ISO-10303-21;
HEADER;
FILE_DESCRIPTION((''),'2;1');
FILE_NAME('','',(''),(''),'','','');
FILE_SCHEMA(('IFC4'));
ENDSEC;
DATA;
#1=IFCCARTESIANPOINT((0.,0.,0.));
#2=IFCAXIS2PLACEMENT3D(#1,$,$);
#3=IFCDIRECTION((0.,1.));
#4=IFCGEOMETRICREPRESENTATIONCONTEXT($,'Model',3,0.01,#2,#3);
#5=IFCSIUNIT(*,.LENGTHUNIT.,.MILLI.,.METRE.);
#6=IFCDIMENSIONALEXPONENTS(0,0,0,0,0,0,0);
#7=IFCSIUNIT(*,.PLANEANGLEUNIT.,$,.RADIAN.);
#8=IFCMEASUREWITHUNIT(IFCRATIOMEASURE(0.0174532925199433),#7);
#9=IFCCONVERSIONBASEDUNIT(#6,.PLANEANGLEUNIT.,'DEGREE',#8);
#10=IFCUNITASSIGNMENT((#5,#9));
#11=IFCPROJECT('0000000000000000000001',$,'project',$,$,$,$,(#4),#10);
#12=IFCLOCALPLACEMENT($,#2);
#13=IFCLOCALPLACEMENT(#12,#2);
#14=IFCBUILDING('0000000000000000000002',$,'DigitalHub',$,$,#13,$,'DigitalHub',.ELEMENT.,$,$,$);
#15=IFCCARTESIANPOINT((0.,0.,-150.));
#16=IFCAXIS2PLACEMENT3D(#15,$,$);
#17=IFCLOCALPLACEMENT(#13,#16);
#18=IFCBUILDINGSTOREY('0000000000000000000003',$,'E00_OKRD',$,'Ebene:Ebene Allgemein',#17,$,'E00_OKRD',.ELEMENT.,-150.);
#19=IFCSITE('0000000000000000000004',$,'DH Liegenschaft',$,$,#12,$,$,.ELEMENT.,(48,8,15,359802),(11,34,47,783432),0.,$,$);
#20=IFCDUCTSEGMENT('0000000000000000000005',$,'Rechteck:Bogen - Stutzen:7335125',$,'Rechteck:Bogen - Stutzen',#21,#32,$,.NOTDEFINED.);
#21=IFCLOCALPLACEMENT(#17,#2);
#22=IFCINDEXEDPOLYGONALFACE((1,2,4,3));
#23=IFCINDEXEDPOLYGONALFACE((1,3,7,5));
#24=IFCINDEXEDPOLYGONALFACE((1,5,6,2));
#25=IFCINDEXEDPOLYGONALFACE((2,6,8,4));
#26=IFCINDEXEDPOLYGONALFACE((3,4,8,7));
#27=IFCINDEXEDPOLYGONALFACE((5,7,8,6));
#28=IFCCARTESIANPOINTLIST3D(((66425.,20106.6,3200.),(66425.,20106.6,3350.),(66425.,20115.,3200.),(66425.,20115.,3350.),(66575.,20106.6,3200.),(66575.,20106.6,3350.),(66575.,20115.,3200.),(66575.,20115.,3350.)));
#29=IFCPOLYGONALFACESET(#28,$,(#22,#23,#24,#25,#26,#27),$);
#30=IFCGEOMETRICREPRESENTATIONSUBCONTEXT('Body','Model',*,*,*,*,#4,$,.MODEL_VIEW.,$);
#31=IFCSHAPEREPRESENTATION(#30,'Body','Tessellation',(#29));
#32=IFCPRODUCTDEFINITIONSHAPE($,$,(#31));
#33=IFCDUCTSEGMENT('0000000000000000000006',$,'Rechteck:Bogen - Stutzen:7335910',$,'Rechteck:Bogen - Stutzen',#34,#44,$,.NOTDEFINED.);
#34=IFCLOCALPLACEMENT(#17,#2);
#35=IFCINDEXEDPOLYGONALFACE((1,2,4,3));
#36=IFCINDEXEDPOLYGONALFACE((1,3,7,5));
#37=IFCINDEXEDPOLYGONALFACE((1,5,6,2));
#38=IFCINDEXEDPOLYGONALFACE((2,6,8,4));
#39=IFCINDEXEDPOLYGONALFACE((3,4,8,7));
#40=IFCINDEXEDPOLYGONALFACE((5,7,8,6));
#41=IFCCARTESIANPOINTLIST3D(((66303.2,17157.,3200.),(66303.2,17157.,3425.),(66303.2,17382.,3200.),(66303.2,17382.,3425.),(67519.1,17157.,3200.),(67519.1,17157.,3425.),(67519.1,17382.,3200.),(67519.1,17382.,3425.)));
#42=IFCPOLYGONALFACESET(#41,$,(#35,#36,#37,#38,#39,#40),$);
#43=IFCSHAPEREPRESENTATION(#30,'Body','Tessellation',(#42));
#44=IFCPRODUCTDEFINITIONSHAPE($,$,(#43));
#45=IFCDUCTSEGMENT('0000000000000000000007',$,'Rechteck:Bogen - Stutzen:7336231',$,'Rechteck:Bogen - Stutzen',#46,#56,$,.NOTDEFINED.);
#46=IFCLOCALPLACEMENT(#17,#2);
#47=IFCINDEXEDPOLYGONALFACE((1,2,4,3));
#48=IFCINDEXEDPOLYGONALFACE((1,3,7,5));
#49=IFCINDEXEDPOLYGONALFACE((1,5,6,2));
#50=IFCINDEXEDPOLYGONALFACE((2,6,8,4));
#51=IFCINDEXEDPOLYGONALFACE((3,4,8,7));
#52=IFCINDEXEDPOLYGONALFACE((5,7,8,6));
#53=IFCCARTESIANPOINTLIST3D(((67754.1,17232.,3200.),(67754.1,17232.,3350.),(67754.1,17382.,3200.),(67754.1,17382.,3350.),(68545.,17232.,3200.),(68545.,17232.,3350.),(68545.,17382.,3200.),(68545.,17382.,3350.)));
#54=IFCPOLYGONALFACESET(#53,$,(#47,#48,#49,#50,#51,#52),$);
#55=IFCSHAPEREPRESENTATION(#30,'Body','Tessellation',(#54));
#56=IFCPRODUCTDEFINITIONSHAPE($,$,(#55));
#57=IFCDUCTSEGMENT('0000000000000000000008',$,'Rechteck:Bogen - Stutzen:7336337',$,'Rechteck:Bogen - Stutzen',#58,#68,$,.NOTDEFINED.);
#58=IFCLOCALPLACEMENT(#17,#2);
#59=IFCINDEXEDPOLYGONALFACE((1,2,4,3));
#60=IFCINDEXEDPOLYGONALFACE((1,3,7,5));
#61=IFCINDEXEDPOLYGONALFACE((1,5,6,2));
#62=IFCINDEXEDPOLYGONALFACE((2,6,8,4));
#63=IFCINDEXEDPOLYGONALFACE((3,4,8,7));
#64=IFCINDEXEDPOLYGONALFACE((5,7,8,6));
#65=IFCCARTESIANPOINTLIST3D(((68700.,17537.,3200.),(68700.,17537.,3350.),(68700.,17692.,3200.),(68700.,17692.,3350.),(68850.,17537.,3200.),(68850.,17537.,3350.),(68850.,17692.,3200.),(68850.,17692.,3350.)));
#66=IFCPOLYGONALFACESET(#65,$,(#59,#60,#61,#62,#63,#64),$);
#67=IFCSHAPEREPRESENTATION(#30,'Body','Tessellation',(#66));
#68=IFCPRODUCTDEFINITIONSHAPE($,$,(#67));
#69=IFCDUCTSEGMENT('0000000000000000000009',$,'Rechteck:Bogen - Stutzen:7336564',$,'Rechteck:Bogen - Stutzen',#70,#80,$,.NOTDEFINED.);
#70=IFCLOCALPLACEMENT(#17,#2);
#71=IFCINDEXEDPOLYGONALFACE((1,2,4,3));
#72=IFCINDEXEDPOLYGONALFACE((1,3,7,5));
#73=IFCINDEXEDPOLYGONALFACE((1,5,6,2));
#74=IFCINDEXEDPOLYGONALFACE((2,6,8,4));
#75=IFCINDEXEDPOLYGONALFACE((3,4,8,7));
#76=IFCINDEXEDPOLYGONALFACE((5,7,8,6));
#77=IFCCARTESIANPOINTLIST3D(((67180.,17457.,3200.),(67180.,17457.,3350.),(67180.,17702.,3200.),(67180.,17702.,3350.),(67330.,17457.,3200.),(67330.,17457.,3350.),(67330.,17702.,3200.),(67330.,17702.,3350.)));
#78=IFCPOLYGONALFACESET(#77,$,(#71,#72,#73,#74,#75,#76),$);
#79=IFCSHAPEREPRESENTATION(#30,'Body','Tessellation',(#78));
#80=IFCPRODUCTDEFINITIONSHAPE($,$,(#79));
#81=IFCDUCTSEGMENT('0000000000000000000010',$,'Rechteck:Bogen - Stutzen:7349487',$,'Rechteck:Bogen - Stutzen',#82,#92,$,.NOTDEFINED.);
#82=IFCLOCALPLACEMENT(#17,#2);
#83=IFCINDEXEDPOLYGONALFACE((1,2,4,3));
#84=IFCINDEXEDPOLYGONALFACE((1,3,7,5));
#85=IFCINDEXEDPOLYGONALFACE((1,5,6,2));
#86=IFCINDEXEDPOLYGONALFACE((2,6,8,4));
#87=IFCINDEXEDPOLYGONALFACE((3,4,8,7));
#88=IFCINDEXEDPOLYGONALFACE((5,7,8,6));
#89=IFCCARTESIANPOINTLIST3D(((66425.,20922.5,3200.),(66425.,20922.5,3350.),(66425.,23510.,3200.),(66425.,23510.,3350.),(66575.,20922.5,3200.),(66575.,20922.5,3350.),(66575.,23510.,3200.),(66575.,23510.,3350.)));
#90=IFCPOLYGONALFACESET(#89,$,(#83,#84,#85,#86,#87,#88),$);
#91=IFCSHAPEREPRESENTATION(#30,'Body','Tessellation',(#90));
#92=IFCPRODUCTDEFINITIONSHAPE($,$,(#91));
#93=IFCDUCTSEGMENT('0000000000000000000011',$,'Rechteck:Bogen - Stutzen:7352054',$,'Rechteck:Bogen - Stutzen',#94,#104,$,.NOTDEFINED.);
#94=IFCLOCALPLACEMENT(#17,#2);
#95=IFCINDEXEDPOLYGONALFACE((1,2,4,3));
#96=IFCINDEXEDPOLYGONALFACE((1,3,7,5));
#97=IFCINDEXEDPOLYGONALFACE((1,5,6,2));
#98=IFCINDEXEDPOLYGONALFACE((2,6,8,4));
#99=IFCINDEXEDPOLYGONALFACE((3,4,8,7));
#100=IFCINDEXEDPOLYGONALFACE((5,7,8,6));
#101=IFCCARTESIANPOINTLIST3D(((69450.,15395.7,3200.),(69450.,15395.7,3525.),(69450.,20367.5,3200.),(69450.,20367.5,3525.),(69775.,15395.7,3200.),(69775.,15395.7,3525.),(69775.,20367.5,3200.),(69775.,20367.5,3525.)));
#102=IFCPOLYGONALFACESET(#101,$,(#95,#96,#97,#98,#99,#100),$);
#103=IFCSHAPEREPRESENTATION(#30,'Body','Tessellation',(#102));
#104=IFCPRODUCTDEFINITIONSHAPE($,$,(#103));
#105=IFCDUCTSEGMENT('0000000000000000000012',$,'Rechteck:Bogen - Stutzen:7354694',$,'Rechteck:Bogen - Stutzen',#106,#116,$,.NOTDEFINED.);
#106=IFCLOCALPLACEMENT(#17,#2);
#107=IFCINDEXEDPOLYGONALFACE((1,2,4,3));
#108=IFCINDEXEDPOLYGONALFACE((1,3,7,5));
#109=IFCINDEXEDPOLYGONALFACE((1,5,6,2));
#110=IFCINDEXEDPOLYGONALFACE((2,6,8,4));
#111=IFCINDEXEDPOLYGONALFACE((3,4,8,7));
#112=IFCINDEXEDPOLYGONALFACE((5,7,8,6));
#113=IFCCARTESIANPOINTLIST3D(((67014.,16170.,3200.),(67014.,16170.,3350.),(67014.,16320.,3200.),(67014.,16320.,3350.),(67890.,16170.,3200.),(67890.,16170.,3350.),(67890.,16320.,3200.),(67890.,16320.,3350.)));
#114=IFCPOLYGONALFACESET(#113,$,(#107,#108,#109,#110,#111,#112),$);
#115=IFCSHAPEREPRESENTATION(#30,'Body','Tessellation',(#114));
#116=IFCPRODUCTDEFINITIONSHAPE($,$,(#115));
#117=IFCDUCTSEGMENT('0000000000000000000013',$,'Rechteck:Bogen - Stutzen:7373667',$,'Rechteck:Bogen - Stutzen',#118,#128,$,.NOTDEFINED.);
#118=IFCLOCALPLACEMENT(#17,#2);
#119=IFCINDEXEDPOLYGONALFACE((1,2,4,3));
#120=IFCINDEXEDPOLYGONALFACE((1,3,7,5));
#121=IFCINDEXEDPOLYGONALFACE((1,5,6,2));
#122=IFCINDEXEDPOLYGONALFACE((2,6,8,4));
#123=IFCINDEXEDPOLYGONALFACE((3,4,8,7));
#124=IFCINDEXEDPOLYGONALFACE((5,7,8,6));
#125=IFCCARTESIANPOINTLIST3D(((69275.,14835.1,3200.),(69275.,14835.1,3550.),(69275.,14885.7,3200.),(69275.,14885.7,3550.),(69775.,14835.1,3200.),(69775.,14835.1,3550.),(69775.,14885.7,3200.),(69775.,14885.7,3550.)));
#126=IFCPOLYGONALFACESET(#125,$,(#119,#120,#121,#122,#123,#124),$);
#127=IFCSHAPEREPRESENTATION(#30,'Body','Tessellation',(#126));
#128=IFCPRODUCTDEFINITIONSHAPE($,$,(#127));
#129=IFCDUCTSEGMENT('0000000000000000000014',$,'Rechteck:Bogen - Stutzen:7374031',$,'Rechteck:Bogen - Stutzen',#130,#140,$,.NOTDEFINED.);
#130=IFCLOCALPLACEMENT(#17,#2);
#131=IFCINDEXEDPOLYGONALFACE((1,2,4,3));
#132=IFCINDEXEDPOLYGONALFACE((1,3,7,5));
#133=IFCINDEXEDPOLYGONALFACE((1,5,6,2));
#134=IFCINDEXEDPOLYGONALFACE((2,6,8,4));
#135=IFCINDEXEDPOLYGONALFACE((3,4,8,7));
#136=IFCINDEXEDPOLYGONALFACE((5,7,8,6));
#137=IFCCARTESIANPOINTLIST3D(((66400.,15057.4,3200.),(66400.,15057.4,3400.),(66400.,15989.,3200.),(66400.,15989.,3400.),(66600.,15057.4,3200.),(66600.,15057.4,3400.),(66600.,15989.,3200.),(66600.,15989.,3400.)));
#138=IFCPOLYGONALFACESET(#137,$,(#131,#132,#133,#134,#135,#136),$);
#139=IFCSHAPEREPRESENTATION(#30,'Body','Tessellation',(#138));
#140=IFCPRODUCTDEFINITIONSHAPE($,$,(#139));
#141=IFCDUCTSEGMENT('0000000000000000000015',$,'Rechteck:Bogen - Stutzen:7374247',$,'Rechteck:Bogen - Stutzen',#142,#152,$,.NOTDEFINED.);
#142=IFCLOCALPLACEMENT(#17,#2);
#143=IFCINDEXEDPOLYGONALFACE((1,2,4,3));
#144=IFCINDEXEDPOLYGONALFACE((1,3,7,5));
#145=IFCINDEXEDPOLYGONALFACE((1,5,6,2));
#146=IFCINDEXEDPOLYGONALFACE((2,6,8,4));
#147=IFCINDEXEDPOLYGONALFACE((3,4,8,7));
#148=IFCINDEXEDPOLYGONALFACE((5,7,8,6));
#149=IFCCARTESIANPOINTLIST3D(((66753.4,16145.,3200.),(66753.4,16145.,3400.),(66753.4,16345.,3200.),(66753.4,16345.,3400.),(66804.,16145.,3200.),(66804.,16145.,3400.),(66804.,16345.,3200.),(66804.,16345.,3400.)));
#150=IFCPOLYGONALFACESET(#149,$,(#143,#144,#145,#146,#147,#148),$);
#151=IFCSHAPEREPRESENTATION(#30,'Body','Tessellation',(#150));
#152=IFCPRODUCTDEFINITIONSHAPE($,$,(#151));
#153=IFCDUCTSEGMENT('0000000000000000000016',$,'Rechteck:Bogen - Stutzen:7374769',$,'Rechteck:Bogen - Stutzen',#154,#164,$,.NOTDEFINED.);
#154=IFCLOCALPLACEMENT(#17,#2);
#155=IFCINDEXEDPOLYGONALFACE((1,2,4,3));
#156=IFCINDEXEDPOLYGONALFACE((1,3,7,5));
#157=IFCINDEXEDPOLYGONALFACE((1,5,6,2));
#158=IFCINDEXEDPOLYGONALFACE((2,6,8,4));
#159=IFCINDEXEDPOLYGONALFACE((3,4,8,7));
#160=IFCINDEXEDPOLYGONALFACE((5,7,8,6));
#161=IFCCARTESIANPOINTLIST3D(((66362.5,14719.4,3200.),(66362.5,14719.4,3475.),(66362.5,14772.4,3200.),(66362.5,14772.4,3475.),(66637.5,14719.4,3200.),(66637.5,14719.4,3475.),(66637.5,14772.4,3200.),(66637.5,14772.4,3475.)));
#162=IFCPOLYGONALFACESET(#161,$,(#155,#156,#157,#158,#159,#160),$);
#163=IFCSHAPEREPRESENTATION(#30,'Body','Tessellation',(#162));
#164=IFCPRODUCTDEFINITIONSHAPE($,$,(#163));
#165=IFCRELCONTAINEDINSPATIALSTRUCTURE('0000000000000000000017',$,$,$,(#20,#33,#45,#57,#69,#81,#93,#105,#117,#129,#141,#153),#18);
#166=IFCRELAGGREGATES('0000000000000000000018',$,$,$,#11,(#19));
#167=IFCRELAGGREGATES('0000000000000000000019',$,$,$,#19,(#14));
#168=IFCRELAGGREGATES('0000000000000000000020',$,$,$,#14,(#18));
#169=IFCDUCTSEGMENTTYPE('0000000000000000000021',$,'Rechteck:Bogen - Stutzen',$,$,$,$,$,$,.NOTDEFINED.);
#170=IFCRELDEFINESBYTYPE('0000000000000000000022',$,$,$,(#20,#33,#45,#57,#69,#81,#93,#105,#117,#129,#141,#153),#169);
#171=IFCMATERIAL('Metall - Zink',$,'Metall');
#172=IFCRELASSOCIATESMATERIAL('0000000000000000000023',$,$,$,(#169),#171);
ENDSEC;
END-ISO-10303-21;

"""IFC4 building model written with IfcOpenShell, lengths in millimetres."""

from ifc_helpers import new_model, entity, si_unit, converted_unit, direction, frame, origin, place, context, subcontext, project, spatial, indexed_curve, outline, extrude, material, type_object, element, save


model = new_model("IFC4")

# Units and contexts
model_context = context("Model", 3, precision=0.01, world=origin(), true_north=direction((0.0, 1.0)))
body_context = subcontext(model_context, "Body", "Model", "MODEL_VIEW")
ifc_project = project(units=[si_unit("LENGTHUNIT", "METRE", prefix="MILLI"), converted_unit("PLANEANGLEUNIT", "DEGREE", entity("IfcRatioMeasure", 0.0174532925199433), si_unit("PLANEANGLEUNIT", "RADIAN"), dimensions=[0, 0, 0, 0, 0, 0, 0])], contexts=[model_context])

# Site, building, storey
site_placement = place(None, origin())
site = spatial("IfcSite", under=ifc_project, at=site_placement, Name="DH Liegenschaft", CompositionType="ELEMENT", RefLatitude=(48, 8, 15, 359802), RefLongitude=(11, 34, 47, 783432), RefElevation=0.0)
building_placement = place(site_placement, origin())
building = spatial("IfcBuilding", under=site, at=building_placement, Name="DigitalHub", LongName="DigitalHub", CompositionType="ELEMENT")
storey_placement = place(building_placement, frame((0.0, 0.0, -150.0)))
storey = spatial("IfcBuildingStorey", under=building, at=storey_placement, Name="E00_OKRD", ObjectType="Ebene:Ebene Allgemein", LongName="E00_OKRD", CompositionType="ELEMENT", Elevation=-150.0)

# Duct segments
ifc_material_1 = material(Name="Metall - Zink", Category="Metall")
duct_segment_type_1 = type_object("IfcDuctSegmentType", Name="Rechteck:Bogen - Stutzen", PredefinedType="NOTDEFINED", material=ifc_material_1)
duct_segment_1_placement = place(storey_placement, frame((66425.0, 20106.6, 3200.0)))
element("IfcDuctSegment", 1, at=duct_segment_1_placement, inside=storey, type_object=duct_segment_type_1, Name="Rechteck:Bogen - Stutzen:7335125", ObjectType="Rechteck:Bogen - Stutzen", PredefinedType="NOTDEFINED", context=body_context, shape_type="SweptSolid", body=[
    extrude(outline(indexed_curve([(-4.2, -75.0), (4.2, -75.0), (4.2, 75.0), (-4.2, 75.0), (-4.2, -75.0)], self_intersect=False)), frame((75.0, 4.2, 0.0), z_axis=(0.0, 0.0, 1.0), x_axis=(0.0, -1.0, 0.0)), (0.0, 0.0, 1.0), 150.0),
])
duct_segment_2_placement = place(storey_placement, frame((66303.2, 17157.0, 3200.0)))
element("IfcDuctSegment", 2, at=duct_segment_2_placement, inside=storey, type_object=duct_segment_type_1, Name="Rechteck:Bogen - Stutzen:7335910", ObjectType="Rechteck:Bogen - Stutzen", PredefinedType="NOTDEFINED", context=body_context, shape_type="SweptSolid", body=[
    extrude(outline(indexed_curve([(-607.9, -112.5), (607.9, -112.5), (607.9, 112.5), (-607.9, 112.5), (-607.9, -112.5)], self_intersect=False)), frame((607.9, 112.5, 0.0)), (0.0, 0.0, 1.0), 225.0),
])
duct_segment_3_placement = place(storey_placement, frame((67754.1, 17232.0, 3200.0)))
element("IfcDuctSegment", 3, at=duct_segment_3_placement, inside=storey, type_object=duct_segment_type_1, Name="Rechteck:Bogen - Stutzen:7336231", ObjectType="Rechteck:Bogen - Stutzen", PredefinedType="NOTDEFINED", context=body_context, shape_type="SweptSolid", body=[
    extrude(outline(indexed_curve([(-395.4, -75.0), (395.4, -75.0), (395.4, 75.0), (-395.4, 75.0), (-395.4, -75.0)], self_intersect=False)), frame((395.4, 75.0, 0.0), z_axis=(0.0, 0.0, 1.0), x_axis=(-1.0, 0.0, 0.0)), (0.0, 0.0, 1.0), 150.0),
])
duct_segment_4_placement = place(storey_placement, frame((68700.0, 17537.0, 3200.0)))
element("IfcDuctSegment", 4, at=duct_segment_4_placement, inside=storey, type_object=duct_segment_type_1, Name="Rechteck:Bogen - Stutzen:7336337", ObjectType="Rechteck:Bogen - Stutzen", PredefinedType="NOTDEFINED", context=body_context, shape_type="SweptSolid", body=[
    extrude(outline(indexed_curve([(-77.5, -75.0), (77.5, -75.0), (77.5, 75.0), (-77.5, 75.0), (-77.5, -75.0)], self_intersect=False)), frame((75.0, 77.5, 0.0), z_axis=(0.0, 0.0, 1.0), x_axis=(0.0, 1.0, 0.0)), (0.0, 0.0, 1.0), 150.0),
])
duct_segment_5_placement = place(storey_placement, frame((67180.0, 17457.0, 3200.0)))
element("IfcDuctSegment", 5, at=duct_segment_5_placement, inside=storey, type_object=duct_segment_type_1, Name="Rechteck:Bogen - Stutzen:7336564", ObjectType="Rechteck:Bogen - Stutzen", PredefinedType="NOTDEFINED", context=body_context, shape_type="SweptSolid", body=[
    extrude(outline(indexed_curve([(-122.5, -75.0), (122.5, -75.0), (122.5, 75.0), (-122.5, 75.0), (-122.5, -75.0)], self_intersect=False)), frame((75.0, 122.5, 0.0), z_axis=(0.0, 0.0, 1.0), x_axis=(0.0, 1.0, 0.0)), (0.0, 0.0, 1.0), 150.0),
])
duct_segment_6_placement = place(storey_placement, frame((66425.0, 20922.5, 3200.0)))
element("IfcDuctSegment", 6, at=duct_segment_6_placement, inside=storey, type_object=duct_segment_type_1, Name="Rechteck:Bogen - Stutzen:7349487", ObjectType="Rechteck:Bogen - Stutzen", PredefinedType="NOTDEFINED", context=body_context, shape_type="SweptSolid", body=[
    extrude(outline(indexed_curve([(-1293.7, -75.0), (1293.7, -75.0), (1293.7, 75.0), (-1293.7, 75.0), (-1293.7, -75.0)], self_intersect=False)), frame((75.0, 1293.7, 0.0), z_axis=(0.0, 0.0, 1.0), x_axis=(0.0, 1.0, 0.0)), (0.0, 0.0, 1.0), 150.0),
])
duct_segment_7_placement = place(storey_placement, frame((69450.0, 15395.7, 3200.0)))
element("IfcDuctSegment", 7, at=duct_segment_7_placement, inside=storey, type_object=duct_segment_type_1, Name="Rechteck:Bogen - Stutzen:7352054", ObjectType="Rechteck:Bogen - Stutzen", PredefinedType="NOTDEFINED", context=body_context, shape_type="SweptSolid", body=[
    extrude(outline(indexed_curve([(-2485.9, -162.5), (2485.9, -162.5), (2485.9, 162.5), (-2485.9, 162.5), (-2485.9, -162.5)], self_intersect=False)), frame((162.5, 2485.9, 0.0), z_axis=(0.0, 0.0, 1.0), x_axis=(0.0, -1.0, 0.0)), (0.0, 0.0, 1.0), 325.0),
])
duct_segment_8_placement = place(storey_placement, frame((67014.0, 16170.0, 3200.0)))
element("IfcDuctSegment", 8, at=duct_segment_8_placement, inside=storey, type_object=duct_segment_type_1, Name="Rechteck:Bogen - Stutzen:7354694", ObjectType="Rechteck:Bogen - Stutzen", PredefinedType="NOTDEFINED", context=body_context, shape_type="SweptSolid", body=[
    extrude(outline(indexed_curve([(-438.0, -75.0), (438.0, -75.0), (438.0, 75.0), (-438.0, 75.0), (-438.0, -75.0)], self_intersect=False)), frame((438.0, 75.0, 0.0), z_axis=(0.0, 0.0, 1.0), x_axis=(-1.0, 0.0, 0.0)), (0.0, 0.0, 1.0), 150.0),
])
duct_segment_9_placement = place(storey_placement, frame((69275.0, 14835.1, 3200.0)))
element("IfcDuctSegment", 9, at=duct_segment_9_placement, inside=storey, type_object=duct_segment_type_1, Name="Rechteck:Bogen - Stutzen:7373667", ObjectType="Rechteck:Bogen - Stutzen", PredefinedType="NOTDEFINED", context=body_context, shape_type="SweptSolid", body=[
    extrude(outline(indexed_curve([(-25.3, -250.0), (25.3, -250.0), (25.3, 250.0), (-25.3, 250.0), (-25.3, -250.0)], self_intersect=False)), frame((250.0, 25.3, 0.0), z_axis=(0.0, 0.0, 1.0), x_axis=(0.0, 1.0, 0.0)), (0.0, 0.0, 1.0), 350.0),
])
duct_segment_10_placement = place(storey_placement, frame((66400.0, 15057.4, 3200.0)))
element("IfcDuctSegment", 10, at=duct_segment_10_placement, inside=storey, type_object=duct_segment_type_1, Name="Rechteck:Bogen - Stutzen:7374031", ObjectType="Rechteck:Bogen - Stutzen", PredefinedType="NOTDEFINED", context=body_context, shape_type="SweptSolid", body=[
    extrude(outline(indexed_curve([(-465.8, -100.0), (465.8, -100.0), (465.8, 100.0), (-465.8, 100.0), (-465.8, -100.0)], self_intersect=False)), frame((100.0, 465.8, 0.0), z_axis=(0.0, 0.0, 1.0), x_axis=(0.0, -1.0, 0.0)), (0.0, 0.0, 1.0), 200.0),
])
duct_segment_11_placement = place(storey_placement, frame((66753.4, 16145.0, 3200.0)))
element("IfcDuctSegment", 11, at=duct_segment_11_placement, inside=storey, type_object=duct_segment_type_1, Name="Rechteck:Bogen - Stutzen:7374247", ObjectType="Rechteck:Bogen - Stutzen", PredefinedType="NOTDEFINED", context=body_context, shape_type="SweptSolid", body=[
    extrude(outline(indexed_curve([(-25.3, -100.0), (25.3, -100.0), (25.3, 100.0), (-25.3, 100.0), (-25.3, -100.0)], self_intersect=False)), frame((25.3, 100.0, 0.0)), (0.0, 0.0, 1.0), 200.0),
])
duct_segment_12_placement = place(storey_placement, frame((66362.5, 14719.4, 3200.0)))
element("IfcDuctSegment", 12, at=duct_segment_12_placement, inside=storey, type_object=duct_segment_type_1, Name="Rechteck:Bogen - Stutzen:7374769", ObjectType="Rechteck:Bogen - Stutzen", PredefinedType="NOTDEFINED", context=body_context, shape_type="SweptSolid", body=[
    extrude(outline(indexed_curve([(-26.5, -137.5), (26.5, -137.5), (26.5, 137.5), (-26.5, 137.5), (-26.5, -137.5)], self_intersect=False)), frame((137.5, 26.5, 0.0), z_axis=(0.0, 0.0, 1.0), x_axis=(0.0, 1.0, 0.0)), (0.0, 0.0, 1.0), 275.0),
])

save(model, "model.ifc")
